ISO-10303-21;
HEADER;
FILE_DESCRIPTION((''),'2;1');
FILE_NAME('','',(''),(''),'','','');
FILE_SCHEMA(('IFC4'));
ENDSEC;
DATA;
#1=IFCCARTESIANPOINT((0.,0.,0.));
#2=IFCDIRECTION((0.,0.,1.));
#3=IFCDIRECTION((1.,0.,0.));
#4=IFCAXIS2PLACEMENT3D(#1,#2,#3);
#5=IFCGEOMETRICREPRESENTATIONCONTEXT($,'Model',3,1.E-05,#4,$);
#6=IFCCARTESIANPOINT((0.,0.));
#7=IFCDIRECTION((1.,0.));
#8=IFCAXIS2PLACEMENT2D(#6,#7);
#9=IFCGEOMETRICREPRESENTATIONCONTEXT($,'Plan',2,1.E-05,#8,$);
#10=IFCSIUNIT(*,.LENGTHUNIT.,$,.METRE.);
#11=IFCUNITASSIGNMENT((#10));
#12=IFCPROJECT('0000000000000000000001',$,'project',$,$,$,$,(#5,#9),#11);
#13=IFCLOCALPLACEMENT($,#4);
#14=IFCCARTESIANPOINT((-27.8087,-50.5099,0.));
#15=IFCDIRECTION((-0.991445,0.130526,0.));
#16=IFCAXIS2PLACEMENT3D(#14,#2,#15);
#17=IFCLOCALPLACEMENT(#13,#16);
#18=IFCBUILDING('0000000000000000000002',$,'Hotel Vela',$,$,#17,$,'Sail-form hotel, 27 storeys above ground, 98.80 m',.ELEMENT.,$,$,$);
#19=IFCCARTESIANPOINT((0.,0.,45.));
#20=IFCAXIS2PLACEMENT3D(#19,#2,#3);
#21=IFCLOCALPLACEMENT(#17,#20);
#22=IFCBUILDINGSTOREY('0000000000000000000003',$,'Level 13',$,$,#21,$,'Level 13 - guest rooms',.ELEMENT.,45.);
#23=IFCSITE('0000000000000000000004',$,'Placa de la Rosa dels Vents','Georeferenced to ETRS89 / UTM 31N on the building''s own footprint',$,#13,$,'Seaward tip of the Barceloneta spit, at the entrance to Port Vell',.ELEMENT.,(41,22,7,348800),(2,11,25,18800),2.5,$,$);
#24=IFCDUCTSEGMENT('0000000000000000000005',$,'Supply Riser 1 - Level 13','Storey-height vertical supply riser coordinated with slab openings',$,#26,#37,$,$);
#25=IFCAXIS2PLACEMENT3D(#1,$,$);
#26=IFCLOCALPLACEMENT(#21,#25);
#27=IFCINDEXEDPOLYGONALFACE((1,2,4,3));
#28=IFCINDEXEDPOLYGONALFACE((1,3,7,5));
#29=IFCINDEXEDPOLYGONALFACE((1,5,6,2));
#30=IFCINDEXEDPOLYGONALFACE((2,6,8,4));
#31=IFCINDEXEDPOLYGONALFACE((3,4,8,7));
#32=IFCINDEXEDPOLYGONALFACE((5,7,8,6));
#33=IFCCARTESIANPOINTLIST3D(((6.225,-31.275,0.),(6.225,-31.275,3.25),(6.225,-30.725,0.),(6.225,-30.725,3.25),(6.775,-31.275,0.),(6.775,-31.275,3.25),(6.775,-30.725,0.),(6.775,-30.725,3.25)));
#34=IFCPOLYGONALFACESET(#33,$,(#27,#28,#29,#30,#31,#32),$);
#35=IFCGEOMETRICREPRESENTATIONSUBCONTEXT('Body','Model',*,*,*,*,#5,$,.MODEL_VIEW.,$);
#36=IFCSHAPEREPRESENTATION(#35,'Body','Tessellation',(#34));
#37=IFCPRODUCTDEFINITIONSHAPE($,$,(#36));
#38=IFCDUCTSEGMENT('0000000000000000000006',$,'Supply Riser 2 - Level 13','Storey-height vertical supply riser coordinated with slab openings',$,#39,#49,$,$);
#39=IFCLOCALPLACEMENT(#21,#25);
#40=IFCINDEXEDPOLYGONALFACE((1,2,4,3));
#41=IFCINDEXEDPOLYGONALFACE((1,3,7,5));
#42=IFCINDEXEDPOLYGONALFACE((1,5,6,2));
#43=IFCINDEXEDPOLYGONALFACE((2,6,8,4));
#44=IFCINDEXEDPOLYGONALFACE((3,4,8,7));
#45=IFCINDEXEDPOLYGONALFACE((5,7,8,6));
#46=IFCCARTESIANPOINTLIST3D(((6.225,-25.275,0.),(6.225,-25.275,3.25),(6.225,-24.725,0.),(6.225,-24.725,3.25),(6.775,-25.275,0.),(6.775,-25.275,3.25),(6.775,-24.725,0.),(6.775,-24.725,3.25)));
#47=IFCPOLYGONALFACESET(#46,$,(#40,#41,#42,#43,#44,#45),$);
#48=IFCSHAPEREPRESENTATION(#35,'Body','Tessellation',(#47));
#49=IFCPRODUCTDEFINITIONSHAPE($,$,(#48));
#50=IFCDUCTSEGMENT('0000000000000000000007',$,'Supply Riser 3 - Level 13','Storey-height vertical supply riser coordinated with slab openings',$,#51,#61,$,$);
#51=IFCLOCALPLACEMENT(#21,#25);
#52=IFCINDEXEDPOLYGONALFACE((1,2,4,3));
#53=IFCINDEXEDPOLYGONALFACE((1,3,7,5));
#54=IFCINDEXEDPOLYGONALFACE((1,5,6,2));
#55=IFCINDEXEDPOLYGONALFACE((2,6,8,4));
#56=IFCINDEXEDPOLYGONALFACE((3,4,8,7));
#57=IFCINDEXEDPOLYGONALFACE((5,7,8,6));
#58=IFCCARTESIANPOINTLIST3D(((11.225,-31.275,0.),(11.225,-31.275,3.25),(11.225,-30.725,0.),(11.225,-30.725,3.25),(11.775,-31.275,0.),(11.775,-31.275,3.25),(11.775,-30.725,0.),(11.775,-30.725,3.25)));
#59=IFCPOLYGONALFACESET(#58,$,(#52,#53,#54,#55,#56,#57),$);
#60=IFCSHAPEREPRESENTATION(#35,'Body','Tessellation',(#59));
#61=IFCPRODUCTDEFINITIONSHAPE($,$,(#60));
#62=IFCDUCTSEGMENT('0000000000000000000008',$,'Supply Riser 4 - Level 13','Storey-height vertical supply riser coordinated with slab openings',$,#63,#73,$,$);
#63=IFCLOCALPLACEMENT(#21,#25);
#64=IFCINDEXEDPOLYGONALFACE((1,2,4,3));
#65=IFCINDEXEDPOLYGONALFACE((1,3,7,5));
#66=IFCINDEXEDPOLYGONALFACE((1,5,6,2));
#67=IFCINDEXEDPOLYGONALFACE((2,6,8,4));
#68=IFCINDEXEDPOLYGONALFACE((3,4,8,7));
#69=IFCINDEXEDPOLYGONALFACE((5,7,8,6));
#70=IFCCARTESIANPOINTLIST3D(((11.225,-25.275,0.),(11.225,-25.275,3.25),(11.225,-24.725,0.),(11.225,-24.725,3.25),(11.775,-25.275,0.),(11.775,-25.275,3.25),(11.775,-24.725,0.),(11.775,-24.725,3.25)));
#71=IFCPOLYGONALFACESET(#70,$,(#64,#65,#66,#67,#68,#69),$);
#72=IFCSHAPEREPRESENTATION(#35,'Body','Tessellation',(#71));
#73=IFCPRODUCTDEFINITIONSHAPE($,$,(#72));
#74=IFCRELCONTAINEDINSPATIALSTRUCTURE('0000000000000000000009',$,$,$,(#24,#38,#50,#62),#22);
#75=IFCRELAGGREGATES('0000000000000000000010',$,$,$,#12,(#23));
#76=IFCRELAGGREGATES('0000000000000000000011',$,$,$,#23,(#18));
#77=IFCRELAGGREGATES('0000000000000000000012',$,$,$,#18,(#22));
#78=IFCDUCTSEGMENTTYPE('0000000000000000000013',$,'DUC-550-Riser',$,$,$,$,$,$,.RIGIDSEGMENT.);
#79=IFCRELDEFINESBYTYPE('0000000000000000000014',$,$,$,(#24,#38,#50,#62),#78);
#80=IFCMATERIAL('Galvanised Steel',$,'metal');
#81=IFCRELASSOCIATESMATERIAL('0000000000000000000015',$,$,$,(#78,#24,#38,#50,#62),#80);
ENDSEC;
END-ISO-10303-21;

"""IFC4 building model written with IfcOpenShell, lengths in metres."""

from ifc_helpers import new_model, si_unit, frame, origin_with_axes, origin_2d_with_axis, place, context, subcontext, project, spatial, line, indexed_curve, outline, extrude, material, type_object, element, save


model = new_model("IFC4")

# Units and contexts
model_context = context("Model", 3, precision=1e-05, world=origin_with_axes())
plan_context = context("Plan", 2, precision=1e-05, world=origin_2d_with_axis())
body_context = subcontext(model_context, "Body", "Model", "MODEL_VIEW")
ifc_project = project(units=[si_unit("LENGTHUNIT", "METRE")], contexts=[model_context, plan_context])

# Site, building, storey
site_placement = place(None, origin_with_axes())
site = spatial("IfcSite", under=ifc_project, at=site_placement, Name="Placa de la Rosa dels Vents", Description="Georeferenced to ETRS89 / UTM 31N on the building's own footprint", LongName="Seaward tip of the Barceloneta spit, at the entrance to Port Vell", CompositionType="ELEMENT", RefLatitude=(41, 22, 7, 348800), RefLongitude=(2, 11, 25, 18800), RefElevation=2.5)
building_placement = place(site_placement, frame((-27.8087, -50.5099, 0.0), z_axis=(0.0, 0.0, 1.0), x_axis=(-0.991445, 0.130526, 0.0)))
building = spatial("IfcBuilding", under=site, at=building_placement, Name="Hotel Vela", LongName="Sail-form hotel, 27 storeys above ground, 98.80 m", CompositionType="ELEMENT")
storey_placement = place(building_placement, frame((0.0, 0.0, 45.0), z_axis=(0.0, 0.0, 1.0), x_axis=(1.0, 0.0, 0.0)))
storey = spatial("IfcBuildingStorey", under=building, at=storey_placement, Name="Level 13", LongName="Level 13 - guest rooms", CompositionType="ELEMENT", Elevation=45.0)

# Duct segments
ifc_material = material(Name="Galvanised Steel", Category="metal")
duct_segment_type = type_object("IfcDuctSegmentType", Name="DUC-550-Riser", PredefinedType="RIGIDSEGMENT", material=ifc_material)
for number, where, z_axis, x_axis, name in (
    (1, (6.225, -31.275, 0.0), (0.0, 0.0, 1.0), (1.0, 0.0, 0.0), "Supply Riser 1 - Level 13"),
    (2, (6.225, -25.275, 0.0), (0.0, 0.0, 1.0), (1.0, 0.0, 0.0), "Supply Riser 2 - Level 13"),
    (3, (11.225, -31.275, 0.0), (0.0, 0.0, 1.0), (1.0, 0.0, 0.0), "Supply Riser 3 - Level 13"),
    (4, (11.225, -25.275, 0.0), (0.0, 0.0, 1.0), (1.0, 0.0, 0.0), "Supply Riser 4 - Level 13"),
):
    element("IfcDuctSegment", number, at=place(storey_placement, frame(where, z_axis=z_axis, x_axis=x_axis)), inside=storey, type_object=duct_segment_type, material=ifc_material, Name=name, Description="Storey-height vertical supply riser coordinated with slab openings", context=body_context, shape_type="SweptSolid", body=[
        extrude(outline(indexed_curve([(0.0, 0.0), (0.55, 0.0), (0.55, 0.55), (0.0, 0.55)], segments=[line(1, 2, 3, 4, 1)])), origin_with_axes(), (0.0, 0.0, 1.0), 3.25),
    ])

save(model, "model.ifc")
